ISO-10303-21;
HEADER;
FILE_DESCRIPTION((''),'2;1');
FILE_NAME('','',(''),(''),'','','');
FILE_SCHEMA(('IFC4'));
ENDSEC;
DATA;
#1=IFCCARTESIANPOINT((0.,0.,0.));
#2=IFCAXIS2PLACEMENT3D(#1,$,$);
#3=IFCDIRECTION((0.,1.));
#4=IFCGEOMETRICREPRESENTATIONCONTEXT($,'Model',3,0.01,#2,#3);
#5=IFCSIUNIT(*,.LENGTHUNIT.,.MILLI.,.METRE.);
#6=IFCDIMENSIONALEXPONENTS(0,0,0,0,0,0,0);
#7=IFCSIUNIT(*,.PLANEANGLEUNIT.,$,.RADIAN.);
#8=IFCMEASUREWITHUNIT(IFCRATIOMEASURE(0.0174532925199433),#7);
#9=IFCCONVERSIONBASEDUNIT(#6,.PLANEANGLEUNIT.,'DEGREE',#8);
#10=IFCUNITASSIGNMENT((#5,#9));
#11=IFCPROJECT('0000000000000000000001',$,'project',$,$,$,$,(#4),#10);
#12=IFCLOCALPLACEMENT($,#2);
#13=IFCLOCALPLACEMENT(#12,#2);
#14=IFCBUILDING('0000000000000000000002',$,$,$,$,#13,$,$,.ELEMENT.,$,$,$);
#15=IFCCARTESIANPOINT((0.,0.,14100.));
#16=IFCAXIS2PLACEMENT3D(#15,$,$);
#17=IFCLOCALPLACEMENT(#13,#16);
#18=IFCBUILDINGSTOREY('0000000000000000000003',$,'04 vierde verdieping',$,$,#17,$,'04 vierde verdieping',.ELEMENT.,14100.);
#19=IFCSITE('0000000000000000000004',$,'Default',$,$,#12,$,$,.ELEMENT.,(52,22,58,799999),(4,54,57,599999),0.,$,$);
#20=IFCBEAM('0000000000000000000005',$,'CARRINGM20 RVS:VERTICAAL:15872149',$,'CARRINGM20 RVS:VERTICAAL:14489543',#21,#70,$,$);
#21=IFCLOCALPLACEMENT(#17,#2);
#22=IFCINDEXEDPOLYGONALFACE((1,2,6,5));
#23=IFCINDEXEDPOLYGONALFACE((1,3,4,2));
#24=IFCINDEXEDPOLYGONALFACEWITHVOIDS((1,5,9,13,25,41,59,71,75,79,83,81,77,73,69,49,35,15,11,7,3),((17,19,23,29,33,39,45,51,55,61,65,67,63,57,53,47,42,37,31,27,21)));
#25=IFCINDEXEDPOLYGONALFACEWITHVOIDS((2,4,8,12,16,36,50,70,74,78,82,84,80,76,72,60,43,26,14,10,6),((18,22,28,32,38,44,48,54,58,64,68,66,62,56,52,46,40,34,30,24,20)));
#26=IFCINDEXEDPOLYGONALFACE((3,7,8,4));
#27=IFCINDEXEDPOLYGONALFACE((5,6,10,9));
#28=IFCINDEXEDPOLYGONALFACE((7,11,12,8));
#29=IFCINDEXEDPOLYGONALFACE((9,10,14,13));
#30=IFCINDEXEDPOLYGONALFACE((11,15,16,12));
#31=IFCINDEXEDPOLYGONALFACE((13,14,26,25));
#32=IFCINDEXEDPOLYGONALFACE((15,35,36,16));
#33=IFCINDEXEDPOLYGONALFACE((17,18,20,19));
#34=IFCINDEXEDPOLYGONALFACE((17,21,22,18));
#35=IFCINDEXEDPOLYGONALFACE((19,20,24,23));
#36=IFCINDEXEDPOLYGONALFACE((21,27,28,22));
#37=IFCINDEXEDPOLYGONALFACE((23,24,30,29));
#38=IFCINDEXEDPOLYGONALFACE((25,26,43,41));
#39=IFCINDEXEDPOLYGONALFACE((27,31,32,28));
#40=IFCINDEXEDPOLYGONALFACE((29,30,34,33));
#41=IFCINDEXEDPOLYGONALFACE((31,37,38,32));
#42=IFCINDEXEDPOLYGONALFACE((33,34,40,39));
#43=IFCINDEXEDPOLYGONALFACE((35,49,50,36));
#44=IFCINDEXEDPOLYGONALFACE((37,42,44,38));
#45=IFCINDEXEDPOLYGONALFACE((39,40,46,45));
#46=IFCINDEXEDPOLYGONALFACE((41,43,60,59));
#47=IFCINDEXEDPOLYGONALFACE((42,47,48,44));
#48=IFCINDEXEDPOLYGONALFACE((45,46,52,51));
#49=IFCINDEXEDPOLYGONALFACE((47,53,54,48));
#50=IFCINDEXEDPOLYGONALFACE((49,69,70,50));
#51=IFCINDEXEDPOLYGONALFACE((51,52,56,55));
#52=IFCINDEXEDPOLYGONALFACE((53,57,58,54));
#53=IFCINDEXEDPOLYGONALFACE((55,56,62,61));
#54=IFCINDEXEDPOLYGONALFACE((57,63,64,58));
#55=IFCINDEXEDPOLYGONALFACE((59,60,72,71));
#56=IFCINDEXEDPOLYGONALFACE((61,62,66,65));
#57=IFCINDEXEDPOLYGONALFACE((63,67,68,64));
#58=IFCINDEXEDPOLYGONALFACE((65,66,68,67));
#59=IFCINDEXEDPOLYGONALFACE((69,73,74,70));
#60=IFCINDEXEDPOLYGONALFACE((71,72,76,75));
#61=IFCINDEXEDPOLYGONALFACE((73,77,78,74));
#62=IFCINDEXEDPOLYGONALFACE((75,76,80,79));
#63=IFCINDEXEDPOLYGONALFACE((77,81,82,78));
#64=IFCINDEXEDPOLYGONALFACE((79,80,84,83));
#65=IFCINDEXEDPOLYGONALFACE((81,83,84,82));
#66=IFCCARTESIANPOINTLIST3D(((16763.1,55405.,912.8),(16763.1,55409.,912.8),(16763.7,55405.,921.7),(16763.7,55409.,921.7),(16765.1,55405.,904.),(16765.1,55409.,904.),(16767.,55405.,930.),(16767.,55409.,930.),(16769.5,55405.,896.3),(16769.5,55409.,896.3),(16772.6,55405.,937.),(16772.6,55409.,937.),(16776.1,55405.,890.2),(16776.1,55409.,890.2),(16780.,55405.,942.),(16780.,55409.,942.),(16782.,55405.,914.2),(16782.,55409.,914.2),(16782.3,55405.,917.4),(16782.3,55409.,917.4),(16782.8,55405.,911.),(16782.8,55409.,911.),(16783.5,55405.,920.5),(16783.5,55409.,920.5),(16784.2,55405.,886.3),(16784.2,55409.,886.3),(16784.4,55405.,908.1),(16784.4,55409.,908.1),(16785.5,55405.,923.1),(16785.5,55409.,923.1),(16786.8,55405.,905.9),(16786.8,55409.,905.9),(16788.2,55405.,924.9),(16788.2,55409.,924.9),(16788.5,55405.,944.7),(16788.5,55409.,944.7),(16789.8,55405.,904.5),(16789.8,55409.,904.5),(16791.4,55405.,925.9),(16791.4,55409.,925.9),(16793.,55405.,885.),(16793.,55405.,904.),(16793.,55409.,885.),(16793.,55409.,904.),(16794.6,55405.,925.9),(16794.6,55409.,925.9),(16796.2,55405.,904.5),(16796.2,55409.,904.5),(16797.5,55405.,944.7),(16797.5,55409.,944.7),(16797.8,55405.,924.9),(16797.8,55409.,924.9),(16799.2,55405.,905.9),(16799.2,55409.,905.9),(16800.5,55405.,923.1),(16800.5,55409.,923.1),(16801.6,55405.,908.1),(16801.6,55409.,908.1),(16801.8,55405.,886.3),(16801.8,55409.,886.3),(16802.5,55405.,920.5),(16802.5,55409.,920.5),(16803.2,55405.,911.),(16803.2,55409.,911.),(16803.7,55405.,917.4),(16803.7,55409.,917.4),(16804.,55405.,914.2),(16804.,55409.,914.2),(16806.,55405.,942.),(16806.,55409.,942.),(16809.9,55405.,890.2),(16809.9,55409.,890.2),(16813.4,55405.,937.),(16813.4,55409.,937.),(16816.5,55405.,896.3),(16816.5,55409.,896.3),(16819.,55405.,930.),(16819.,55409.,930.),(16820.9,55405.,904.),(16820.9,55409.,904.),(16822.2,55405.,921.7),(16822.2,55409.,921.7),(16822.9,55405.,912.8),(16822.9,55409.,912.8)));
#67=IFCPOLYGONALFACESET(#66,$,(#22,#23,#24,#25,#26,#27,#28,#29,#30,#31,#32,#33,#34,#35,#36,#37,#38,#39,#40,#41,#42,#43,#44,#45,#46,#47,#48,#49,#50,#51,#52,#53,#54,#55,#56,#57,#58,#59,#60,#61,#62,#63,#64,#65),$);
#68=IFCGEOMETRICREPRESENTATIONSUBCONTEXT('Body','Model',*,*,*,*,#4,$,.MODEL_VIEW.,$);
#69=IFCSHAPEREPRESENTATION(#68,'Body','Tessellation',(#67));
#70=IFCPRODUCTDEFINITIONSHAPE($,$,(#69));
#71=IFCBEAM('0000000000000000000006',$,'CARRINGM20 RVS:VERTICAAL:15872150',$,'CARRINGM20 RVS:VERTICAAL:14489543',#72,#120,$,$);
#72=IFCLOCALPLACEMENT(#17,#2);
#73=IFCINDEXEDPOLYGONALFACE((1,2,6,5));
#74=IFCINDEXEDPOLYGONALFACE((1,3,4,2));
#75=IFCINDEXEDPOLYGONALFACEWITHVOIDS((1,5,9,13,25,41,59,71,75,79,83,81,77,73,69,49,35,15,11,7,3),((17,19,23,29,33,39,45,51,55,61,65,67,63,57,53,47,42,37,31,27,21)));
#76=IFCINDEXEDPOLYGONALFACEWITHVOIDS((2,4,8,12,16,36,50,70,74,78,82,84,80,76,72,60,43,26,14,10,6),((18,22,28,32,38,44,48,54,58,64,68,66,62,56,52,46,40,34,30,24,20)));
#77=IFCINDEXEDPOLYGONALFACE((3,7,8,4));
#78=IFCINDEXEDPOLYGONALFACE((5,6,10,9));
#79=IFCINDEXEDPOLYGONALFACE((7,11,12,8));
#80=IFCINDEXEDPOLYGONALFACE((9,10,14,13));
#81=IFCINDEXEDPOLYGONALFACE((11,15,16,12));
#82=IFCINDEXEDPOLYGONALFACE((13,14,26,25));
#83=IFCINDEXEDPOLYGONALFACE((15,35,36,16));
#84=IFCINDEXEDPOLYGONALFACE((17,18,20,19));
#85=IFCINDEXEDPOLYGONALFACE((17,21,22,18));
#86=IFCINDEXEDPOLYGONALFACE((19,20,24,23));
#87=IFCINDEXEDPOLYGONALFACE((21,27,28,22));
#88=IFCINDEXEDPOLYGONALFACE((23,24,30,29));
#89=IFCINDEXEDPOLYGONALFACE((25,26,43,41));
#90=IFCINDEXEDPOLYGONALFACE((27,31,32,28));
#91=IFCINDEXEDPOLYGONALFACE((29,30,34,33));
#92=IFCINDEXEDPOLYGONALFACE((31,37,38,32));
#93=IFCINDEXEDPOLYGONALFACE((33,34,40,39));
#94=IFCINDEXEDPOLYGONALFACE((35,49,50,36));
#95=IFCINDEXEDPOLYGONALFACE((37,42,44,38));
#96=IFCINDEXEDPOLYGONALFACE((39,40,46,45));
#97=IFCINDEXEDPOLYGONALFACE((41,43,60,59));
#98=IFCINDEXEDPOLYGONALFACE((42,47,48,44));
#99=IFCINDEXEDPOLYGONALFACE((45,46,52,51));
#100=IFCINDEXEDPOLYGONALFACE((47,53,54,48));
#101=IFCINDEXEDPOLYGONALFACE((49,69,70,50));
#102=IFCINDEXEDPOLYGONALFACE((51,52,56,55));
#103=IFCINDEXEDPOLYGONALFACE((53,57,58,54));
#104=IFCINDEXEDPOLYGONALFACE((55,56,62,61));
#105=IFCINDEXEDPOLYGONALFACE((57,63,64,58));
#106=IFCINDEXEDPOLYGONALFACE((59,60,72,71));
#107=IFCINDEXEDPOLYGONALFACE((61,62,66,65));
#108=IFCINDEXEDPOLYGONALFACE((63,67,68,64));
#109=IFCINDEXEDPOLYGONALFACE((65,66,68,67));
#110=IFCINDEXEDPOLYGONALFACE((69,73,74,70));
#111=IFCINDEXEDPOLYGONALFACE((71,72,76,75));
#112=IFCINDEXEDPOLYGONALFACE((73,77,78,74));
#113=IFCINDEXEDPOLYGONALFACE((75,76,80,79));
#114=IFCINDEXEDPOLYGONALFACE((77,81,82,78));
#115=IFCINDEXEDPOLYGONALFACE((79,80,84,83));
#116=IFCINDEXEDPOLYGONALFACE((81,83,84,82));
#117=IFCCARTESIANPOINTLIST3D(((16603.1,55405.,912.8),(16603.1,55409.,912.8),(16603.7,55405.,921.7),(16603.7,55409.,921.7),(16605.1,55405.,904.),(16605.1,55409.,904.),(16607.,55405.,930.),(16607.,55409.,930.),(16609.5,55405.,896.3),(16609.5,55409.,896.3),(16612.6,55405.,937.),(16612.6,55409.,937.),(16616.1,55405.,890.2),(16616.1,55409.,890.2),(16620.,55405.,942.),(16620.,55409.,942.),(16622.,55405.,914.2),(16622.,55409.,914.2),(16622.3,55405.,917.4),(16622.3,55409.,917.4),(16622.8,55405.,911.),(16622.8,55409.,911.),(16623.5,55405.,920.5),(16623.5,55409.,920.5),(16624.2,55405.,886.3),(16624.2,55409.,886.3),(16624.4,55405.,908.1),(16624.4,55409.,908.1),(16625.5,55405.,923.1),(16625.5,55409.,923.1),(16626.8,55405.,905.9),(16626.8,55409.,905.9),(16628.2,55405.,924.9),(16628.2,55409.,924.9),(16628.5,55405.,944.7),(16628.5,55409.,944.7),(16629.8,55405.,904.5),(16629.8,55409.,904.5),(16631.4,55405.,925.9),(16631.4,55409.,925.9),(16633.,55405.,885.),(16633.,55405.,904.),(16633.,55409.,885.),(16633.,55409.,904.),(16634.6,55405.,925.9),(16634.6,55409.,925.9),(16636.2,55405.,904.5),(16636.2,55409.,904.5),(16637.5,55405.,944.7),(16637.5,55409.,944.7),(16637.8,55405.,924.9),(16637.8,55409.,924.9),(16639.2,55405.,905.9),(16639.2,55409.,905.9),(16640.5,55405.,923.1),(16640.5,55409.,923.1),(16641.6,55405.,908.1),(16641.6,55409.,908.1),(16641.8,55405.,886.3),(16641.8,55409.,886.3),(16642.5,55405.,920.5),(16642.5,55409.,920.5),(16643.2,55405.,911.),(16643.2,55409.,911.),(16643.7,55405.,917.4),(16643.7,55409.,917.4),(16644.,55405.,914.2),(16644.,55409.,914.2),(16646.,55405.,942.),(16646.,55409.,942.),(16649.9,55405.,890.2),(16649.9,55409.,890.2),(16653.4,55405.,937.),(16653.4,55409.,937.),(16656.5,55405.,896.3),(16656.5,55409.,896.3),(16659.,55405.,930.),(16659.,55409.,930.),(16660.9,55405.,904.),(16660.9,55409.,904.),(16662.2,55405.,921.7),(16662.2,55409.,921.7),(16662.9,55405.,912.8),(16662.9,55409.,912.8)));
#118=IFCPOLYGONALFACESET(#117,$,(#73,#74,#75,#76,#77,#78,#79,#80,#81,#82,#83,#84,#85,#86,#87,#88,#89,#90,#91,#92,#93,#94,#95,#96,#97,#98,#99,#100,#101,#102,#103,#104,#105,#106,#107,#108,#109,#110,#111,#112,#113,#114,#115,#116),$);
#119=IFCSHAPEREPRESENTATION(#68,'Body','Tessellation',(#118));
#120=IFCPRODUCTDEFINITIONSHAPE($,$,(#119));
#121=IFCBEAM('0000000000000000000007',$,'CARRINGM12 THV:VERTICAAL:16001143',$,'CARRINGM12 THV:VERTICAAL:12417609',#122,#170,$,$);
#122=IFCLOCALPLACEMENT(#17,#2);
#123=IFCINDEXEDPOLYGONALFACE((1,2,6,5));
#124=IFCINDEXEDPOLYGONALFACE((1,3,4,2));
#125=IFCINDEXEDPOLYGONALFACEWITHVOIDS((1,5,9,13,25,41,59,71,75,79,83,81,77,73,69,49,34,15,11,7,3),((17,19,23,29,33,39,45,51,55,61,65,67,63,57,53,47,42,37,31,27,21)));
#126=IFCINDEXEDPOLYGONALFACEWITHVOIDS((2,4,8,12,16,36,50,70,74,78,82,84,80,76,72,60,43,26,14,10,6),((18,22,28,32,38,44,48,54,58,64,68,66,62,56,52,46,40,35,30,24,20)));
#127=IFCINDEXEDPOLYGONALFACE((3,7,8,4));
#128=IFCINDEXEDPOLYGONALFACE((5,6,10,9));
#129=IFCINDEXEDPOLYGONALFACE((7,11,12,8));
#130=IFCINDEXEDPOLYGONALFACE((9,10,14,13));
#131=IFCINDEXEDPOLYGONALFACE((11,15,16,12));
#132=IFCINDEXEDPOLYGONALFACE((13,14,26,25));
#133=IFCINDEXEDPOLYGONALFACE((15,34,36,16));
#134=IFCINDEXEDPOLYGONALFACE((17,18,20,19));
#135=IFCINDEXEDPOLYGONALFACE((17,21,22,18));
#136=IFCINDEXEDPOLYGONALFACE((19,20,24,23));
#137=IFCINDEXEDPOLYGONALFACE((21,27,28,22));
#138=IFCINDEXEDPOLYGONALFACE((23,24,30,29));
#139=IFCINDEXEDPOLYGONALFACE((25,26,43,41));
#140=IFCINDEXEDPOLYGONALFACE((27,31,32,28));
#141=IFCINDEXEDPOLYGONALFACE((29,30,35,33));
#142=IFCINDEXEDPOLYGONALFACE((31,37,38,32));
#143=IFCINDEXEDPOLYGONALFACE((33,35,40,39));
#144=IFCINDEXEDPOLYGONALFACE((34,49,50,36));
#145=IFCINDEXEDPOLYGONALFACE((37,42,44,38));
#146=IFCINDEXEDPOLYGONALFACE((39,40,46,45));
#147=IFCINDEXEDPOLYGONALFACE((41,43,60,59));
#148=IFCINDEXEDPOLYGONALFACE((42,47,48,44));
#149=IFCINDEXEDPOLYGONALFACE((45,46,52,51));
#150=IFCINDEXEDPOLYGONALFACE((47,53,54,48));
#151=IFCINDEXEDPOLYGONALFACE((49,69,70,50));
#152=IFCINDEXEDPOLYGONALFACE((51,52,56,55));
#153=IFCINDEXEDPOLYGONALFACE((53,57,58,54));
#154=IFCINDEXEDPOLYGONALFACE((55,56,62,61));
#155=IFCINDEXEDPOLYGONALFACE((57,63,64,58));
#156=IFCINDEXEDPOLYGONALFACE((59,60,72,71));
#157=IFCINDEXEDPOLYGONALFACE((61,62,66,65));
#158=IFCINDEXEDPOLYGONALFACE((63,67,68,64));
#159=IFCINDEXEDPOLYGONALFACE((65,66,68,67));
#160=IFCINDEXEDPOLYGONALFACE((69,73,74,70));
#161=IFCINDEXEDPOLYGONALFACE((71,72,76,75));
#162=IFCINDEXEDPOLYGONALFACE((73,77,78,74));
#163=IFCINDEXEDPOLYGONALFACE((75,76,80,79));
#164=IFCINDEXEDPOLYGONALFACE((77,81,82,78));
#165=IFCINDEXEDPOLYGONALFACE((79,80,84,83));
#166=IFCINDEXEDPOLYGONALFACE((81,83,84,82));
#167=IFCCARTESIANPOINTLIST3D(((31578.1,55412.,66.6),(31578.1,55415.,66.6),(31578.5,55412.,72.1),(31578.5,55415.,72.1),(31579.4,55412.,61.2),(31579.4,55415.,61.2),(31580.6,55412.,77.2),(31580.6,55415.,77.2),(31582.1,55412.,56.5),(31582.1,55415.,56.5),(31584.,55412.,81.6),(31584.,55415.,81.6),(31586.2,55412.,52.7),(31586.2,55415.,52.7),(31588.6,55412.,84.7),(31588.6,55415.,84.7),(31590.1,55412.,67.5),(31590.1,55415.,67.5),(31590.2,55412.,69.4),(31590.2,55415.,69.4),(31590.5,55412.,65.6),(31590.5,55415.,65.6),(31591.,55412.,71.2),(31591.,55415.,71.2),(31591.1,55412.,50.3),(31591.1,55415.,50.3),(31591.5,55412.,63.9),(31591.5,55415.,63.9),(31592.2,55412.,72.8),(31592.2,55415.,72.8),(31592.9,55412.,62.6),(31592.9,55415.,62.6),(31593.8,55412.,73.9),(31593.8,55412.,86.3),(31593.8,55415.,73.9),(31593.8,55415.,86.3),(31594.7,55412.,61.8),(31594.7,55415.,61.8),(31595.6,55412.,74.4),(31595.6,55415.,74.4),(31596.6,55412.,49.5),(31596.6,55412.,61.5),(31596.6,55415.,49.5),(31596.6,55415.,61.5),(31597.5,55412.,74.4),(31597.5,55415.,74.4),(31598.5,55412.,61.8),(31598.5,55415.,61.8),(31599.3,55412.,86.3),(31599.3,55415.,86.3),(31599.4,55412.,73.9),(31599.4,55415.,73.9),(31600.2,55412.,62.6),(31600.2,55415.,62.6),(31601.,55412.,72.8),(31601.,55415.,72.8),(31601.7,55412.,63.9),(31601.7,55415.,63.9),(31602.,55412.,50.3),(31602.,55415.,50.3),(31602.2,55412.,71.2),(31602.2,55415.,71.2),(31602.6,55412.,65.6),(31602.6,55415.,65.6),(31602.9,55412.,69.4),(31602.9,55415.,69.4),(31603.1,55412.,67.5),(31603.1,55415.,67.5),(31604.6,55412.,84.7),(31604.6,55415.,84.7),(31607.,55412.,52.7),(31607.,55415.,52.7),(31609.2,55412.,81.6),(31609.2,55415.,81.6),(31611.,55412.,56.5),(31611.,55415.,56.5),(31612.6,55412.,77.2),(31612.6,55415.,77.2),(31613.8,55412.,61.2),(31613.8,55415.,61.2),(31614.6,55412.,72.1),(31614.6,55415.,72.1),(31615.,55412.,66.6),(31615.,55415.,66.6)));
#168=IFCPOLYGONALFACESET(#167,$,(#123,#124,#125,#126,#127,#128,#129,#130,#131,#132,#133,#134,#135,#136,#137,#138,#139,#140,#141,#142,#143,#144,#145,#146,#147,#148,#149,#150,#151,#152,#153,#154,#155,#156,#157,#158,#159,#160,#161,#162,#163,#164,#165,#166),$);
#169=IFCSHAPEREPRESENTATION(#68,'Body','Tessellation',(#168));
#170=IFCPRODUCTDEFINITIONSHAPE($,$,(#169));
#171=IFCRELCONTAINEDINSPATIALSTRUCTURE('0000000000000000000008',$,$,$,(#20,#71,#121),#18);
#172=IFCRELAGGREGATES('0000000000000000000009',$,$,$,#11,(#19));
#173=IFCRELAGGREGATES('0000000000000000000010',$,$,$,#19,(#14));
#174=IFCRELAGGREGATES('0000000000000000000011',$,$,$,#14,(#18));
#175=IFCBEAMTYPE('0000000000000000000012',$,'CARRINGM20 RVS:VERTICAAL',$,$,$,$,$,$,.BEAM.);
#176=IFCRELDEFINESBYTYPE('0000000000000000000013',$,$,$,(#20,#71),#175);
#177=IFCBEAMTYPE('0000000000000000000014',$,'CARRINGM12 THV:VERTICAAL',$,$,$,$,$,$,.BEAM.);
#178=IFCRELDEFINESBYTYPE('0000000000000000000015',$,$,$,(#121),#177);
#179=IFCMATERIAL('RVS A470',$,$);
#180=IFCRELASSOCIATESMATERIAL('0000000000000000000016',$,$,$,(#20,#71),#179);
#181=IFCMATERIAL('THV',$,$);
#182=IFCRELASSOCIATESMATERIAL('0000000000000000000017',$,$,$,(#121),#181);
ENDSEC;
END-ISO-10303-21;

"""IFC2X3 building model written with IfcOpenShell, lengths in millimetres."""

from ifc_helpers import new_model, entity, si_unit, converted_unit, direction, frame, origin, origin_2d_with_axis, place, context, subcontext, project, spatial, hollow_circle, extrude, material, type_object, element, save


model = new_model("IFC2X3")

# Units and contexts
model_context = context("Model", 3, precision=0.01, world=origin(), true_north=direction((0.0, 1.0)))
body_context = subcontext(model_context, "Body", "Model", "MODEL_VIEW")
ifc_project = project(units=[si_unit("LENGTHUNIT", "METRE", prefix="MILLI"), converted_unit("PLANEANGLEUNIT", "DEGREE", entity("IfcRatioMeasure", 0.0174532925199433), si_unit("PLANEANGLEUNIT", "RADIAN"), dimensions=[0, 0, 0, 0, 0, 0, 0])], contexts=[model_context])

# Site, building, storey
site_placement = place(None, origin())
site = spatial("IfcSite", under=ifc_project, at=site_placement, Name="Default", CompositionType="ELEMENT", RefLatitude=(52, 22, 58, 799999), RefLongitude=(4, 54, 57, 599999), RefElevation=0.0)
building_placement = place(site_placement, origin())
building = spatial("IfcBuilding", under=site, at=building_placement, CompositionType="ELEMENT")
storey_placement = place(building_placement, frame((0.0, 0.0, 14100.0)))
storey = spatial("IfcBuildingStorey", under=building, at=storey_placement, Name="04 vierde verdieping", LongName="04 vierde verdieping", CompositionType="ELEMENT", Elevation=14100.0)

# Beams
ifc_material_1 = material(Name="RVS A470")
beam_type_1 = type_object("IfcBeamType", Name="CARRINGM20 RVS:VERTICAAL", PredefinedType="BEAM")
beam_1_placement = place(storey_placement, origin())
element("IfcBeam", 1, at=beam_1_placement, inside=storey, type_object=beam_type_1, material=ifc_material_1, Name="CARRINGM20 RVS:VERTICAAL:15872149", ObjectType="CARRINGM20 RVS:VERTICAAL:14489543", context=body_context, shape_type="SweptSolid", body=[
    extrude(hollow_circle(Radius=30.0, WallThickness=19.0, at=origin_2d_with_axis()), frame((16793.0, 55405.0, 915.0), z_axis=(0.0, 1.0, 0.0), x_axis=(0.0, 0.0, -1.0)), (0.0, 0.0, 1.0), 4.0),
])
beam_2_placement = place(storey_placement, origin())
element("IfcBeam", 2, at=beam_2_placement, inside=storey, type_object=beam_type_1, material=ifc_material_1, Name="CARRINGM20 RVS:VERTICAAL:15872150", ObjectType="CARRINGM20 RVS:VERTICAAL:14489543", context=body_context, shape_type="SweptSolid", body=[
    extrude(hollow_circle(Radius=30.0, WallThickness=19.0, at=origin_2d_with_axis()), frame((16633.0, 55405.0, 915.0), z_axis=(0.0, 1.0, 0.0), x_axis=(0.0, 0.0, -1.0)), (0.0, 0.0, 1.0), 4.0),
])
ifc_material_2 = material(Name="THV")
beam_type_2 = type_object("IfcBeamType", Name="CARRINGM12 THV:VERTICAAL", PredefinedType="BEAM")
beam_3_placement = place(storey_placement, origin())
element("IfcBeam", 3, at=beam_3_placement, inside=storey, type_object=beam_type_2, material=ifc_material_2, Name="CARRINGM12 THV:VERTICAAL:16001143", ObjectType="CARRINGM12 THV:VERTICAAL:12417609", context=body_context, shape_type="SweptSolid", body=[
    extrude(hollow_circle(Radius=18.5, WallThickness=12.0, at=origin_2d_with_axis()), frame((31596.6, 55412.0, 68.0), z_axis=(0.0, 1.0, 0.0), x_axis=(0.0, 0.0, -1.0)), (0.0, 0.0, 1.0), 3.0),
])

save(model, "model.ifc")
